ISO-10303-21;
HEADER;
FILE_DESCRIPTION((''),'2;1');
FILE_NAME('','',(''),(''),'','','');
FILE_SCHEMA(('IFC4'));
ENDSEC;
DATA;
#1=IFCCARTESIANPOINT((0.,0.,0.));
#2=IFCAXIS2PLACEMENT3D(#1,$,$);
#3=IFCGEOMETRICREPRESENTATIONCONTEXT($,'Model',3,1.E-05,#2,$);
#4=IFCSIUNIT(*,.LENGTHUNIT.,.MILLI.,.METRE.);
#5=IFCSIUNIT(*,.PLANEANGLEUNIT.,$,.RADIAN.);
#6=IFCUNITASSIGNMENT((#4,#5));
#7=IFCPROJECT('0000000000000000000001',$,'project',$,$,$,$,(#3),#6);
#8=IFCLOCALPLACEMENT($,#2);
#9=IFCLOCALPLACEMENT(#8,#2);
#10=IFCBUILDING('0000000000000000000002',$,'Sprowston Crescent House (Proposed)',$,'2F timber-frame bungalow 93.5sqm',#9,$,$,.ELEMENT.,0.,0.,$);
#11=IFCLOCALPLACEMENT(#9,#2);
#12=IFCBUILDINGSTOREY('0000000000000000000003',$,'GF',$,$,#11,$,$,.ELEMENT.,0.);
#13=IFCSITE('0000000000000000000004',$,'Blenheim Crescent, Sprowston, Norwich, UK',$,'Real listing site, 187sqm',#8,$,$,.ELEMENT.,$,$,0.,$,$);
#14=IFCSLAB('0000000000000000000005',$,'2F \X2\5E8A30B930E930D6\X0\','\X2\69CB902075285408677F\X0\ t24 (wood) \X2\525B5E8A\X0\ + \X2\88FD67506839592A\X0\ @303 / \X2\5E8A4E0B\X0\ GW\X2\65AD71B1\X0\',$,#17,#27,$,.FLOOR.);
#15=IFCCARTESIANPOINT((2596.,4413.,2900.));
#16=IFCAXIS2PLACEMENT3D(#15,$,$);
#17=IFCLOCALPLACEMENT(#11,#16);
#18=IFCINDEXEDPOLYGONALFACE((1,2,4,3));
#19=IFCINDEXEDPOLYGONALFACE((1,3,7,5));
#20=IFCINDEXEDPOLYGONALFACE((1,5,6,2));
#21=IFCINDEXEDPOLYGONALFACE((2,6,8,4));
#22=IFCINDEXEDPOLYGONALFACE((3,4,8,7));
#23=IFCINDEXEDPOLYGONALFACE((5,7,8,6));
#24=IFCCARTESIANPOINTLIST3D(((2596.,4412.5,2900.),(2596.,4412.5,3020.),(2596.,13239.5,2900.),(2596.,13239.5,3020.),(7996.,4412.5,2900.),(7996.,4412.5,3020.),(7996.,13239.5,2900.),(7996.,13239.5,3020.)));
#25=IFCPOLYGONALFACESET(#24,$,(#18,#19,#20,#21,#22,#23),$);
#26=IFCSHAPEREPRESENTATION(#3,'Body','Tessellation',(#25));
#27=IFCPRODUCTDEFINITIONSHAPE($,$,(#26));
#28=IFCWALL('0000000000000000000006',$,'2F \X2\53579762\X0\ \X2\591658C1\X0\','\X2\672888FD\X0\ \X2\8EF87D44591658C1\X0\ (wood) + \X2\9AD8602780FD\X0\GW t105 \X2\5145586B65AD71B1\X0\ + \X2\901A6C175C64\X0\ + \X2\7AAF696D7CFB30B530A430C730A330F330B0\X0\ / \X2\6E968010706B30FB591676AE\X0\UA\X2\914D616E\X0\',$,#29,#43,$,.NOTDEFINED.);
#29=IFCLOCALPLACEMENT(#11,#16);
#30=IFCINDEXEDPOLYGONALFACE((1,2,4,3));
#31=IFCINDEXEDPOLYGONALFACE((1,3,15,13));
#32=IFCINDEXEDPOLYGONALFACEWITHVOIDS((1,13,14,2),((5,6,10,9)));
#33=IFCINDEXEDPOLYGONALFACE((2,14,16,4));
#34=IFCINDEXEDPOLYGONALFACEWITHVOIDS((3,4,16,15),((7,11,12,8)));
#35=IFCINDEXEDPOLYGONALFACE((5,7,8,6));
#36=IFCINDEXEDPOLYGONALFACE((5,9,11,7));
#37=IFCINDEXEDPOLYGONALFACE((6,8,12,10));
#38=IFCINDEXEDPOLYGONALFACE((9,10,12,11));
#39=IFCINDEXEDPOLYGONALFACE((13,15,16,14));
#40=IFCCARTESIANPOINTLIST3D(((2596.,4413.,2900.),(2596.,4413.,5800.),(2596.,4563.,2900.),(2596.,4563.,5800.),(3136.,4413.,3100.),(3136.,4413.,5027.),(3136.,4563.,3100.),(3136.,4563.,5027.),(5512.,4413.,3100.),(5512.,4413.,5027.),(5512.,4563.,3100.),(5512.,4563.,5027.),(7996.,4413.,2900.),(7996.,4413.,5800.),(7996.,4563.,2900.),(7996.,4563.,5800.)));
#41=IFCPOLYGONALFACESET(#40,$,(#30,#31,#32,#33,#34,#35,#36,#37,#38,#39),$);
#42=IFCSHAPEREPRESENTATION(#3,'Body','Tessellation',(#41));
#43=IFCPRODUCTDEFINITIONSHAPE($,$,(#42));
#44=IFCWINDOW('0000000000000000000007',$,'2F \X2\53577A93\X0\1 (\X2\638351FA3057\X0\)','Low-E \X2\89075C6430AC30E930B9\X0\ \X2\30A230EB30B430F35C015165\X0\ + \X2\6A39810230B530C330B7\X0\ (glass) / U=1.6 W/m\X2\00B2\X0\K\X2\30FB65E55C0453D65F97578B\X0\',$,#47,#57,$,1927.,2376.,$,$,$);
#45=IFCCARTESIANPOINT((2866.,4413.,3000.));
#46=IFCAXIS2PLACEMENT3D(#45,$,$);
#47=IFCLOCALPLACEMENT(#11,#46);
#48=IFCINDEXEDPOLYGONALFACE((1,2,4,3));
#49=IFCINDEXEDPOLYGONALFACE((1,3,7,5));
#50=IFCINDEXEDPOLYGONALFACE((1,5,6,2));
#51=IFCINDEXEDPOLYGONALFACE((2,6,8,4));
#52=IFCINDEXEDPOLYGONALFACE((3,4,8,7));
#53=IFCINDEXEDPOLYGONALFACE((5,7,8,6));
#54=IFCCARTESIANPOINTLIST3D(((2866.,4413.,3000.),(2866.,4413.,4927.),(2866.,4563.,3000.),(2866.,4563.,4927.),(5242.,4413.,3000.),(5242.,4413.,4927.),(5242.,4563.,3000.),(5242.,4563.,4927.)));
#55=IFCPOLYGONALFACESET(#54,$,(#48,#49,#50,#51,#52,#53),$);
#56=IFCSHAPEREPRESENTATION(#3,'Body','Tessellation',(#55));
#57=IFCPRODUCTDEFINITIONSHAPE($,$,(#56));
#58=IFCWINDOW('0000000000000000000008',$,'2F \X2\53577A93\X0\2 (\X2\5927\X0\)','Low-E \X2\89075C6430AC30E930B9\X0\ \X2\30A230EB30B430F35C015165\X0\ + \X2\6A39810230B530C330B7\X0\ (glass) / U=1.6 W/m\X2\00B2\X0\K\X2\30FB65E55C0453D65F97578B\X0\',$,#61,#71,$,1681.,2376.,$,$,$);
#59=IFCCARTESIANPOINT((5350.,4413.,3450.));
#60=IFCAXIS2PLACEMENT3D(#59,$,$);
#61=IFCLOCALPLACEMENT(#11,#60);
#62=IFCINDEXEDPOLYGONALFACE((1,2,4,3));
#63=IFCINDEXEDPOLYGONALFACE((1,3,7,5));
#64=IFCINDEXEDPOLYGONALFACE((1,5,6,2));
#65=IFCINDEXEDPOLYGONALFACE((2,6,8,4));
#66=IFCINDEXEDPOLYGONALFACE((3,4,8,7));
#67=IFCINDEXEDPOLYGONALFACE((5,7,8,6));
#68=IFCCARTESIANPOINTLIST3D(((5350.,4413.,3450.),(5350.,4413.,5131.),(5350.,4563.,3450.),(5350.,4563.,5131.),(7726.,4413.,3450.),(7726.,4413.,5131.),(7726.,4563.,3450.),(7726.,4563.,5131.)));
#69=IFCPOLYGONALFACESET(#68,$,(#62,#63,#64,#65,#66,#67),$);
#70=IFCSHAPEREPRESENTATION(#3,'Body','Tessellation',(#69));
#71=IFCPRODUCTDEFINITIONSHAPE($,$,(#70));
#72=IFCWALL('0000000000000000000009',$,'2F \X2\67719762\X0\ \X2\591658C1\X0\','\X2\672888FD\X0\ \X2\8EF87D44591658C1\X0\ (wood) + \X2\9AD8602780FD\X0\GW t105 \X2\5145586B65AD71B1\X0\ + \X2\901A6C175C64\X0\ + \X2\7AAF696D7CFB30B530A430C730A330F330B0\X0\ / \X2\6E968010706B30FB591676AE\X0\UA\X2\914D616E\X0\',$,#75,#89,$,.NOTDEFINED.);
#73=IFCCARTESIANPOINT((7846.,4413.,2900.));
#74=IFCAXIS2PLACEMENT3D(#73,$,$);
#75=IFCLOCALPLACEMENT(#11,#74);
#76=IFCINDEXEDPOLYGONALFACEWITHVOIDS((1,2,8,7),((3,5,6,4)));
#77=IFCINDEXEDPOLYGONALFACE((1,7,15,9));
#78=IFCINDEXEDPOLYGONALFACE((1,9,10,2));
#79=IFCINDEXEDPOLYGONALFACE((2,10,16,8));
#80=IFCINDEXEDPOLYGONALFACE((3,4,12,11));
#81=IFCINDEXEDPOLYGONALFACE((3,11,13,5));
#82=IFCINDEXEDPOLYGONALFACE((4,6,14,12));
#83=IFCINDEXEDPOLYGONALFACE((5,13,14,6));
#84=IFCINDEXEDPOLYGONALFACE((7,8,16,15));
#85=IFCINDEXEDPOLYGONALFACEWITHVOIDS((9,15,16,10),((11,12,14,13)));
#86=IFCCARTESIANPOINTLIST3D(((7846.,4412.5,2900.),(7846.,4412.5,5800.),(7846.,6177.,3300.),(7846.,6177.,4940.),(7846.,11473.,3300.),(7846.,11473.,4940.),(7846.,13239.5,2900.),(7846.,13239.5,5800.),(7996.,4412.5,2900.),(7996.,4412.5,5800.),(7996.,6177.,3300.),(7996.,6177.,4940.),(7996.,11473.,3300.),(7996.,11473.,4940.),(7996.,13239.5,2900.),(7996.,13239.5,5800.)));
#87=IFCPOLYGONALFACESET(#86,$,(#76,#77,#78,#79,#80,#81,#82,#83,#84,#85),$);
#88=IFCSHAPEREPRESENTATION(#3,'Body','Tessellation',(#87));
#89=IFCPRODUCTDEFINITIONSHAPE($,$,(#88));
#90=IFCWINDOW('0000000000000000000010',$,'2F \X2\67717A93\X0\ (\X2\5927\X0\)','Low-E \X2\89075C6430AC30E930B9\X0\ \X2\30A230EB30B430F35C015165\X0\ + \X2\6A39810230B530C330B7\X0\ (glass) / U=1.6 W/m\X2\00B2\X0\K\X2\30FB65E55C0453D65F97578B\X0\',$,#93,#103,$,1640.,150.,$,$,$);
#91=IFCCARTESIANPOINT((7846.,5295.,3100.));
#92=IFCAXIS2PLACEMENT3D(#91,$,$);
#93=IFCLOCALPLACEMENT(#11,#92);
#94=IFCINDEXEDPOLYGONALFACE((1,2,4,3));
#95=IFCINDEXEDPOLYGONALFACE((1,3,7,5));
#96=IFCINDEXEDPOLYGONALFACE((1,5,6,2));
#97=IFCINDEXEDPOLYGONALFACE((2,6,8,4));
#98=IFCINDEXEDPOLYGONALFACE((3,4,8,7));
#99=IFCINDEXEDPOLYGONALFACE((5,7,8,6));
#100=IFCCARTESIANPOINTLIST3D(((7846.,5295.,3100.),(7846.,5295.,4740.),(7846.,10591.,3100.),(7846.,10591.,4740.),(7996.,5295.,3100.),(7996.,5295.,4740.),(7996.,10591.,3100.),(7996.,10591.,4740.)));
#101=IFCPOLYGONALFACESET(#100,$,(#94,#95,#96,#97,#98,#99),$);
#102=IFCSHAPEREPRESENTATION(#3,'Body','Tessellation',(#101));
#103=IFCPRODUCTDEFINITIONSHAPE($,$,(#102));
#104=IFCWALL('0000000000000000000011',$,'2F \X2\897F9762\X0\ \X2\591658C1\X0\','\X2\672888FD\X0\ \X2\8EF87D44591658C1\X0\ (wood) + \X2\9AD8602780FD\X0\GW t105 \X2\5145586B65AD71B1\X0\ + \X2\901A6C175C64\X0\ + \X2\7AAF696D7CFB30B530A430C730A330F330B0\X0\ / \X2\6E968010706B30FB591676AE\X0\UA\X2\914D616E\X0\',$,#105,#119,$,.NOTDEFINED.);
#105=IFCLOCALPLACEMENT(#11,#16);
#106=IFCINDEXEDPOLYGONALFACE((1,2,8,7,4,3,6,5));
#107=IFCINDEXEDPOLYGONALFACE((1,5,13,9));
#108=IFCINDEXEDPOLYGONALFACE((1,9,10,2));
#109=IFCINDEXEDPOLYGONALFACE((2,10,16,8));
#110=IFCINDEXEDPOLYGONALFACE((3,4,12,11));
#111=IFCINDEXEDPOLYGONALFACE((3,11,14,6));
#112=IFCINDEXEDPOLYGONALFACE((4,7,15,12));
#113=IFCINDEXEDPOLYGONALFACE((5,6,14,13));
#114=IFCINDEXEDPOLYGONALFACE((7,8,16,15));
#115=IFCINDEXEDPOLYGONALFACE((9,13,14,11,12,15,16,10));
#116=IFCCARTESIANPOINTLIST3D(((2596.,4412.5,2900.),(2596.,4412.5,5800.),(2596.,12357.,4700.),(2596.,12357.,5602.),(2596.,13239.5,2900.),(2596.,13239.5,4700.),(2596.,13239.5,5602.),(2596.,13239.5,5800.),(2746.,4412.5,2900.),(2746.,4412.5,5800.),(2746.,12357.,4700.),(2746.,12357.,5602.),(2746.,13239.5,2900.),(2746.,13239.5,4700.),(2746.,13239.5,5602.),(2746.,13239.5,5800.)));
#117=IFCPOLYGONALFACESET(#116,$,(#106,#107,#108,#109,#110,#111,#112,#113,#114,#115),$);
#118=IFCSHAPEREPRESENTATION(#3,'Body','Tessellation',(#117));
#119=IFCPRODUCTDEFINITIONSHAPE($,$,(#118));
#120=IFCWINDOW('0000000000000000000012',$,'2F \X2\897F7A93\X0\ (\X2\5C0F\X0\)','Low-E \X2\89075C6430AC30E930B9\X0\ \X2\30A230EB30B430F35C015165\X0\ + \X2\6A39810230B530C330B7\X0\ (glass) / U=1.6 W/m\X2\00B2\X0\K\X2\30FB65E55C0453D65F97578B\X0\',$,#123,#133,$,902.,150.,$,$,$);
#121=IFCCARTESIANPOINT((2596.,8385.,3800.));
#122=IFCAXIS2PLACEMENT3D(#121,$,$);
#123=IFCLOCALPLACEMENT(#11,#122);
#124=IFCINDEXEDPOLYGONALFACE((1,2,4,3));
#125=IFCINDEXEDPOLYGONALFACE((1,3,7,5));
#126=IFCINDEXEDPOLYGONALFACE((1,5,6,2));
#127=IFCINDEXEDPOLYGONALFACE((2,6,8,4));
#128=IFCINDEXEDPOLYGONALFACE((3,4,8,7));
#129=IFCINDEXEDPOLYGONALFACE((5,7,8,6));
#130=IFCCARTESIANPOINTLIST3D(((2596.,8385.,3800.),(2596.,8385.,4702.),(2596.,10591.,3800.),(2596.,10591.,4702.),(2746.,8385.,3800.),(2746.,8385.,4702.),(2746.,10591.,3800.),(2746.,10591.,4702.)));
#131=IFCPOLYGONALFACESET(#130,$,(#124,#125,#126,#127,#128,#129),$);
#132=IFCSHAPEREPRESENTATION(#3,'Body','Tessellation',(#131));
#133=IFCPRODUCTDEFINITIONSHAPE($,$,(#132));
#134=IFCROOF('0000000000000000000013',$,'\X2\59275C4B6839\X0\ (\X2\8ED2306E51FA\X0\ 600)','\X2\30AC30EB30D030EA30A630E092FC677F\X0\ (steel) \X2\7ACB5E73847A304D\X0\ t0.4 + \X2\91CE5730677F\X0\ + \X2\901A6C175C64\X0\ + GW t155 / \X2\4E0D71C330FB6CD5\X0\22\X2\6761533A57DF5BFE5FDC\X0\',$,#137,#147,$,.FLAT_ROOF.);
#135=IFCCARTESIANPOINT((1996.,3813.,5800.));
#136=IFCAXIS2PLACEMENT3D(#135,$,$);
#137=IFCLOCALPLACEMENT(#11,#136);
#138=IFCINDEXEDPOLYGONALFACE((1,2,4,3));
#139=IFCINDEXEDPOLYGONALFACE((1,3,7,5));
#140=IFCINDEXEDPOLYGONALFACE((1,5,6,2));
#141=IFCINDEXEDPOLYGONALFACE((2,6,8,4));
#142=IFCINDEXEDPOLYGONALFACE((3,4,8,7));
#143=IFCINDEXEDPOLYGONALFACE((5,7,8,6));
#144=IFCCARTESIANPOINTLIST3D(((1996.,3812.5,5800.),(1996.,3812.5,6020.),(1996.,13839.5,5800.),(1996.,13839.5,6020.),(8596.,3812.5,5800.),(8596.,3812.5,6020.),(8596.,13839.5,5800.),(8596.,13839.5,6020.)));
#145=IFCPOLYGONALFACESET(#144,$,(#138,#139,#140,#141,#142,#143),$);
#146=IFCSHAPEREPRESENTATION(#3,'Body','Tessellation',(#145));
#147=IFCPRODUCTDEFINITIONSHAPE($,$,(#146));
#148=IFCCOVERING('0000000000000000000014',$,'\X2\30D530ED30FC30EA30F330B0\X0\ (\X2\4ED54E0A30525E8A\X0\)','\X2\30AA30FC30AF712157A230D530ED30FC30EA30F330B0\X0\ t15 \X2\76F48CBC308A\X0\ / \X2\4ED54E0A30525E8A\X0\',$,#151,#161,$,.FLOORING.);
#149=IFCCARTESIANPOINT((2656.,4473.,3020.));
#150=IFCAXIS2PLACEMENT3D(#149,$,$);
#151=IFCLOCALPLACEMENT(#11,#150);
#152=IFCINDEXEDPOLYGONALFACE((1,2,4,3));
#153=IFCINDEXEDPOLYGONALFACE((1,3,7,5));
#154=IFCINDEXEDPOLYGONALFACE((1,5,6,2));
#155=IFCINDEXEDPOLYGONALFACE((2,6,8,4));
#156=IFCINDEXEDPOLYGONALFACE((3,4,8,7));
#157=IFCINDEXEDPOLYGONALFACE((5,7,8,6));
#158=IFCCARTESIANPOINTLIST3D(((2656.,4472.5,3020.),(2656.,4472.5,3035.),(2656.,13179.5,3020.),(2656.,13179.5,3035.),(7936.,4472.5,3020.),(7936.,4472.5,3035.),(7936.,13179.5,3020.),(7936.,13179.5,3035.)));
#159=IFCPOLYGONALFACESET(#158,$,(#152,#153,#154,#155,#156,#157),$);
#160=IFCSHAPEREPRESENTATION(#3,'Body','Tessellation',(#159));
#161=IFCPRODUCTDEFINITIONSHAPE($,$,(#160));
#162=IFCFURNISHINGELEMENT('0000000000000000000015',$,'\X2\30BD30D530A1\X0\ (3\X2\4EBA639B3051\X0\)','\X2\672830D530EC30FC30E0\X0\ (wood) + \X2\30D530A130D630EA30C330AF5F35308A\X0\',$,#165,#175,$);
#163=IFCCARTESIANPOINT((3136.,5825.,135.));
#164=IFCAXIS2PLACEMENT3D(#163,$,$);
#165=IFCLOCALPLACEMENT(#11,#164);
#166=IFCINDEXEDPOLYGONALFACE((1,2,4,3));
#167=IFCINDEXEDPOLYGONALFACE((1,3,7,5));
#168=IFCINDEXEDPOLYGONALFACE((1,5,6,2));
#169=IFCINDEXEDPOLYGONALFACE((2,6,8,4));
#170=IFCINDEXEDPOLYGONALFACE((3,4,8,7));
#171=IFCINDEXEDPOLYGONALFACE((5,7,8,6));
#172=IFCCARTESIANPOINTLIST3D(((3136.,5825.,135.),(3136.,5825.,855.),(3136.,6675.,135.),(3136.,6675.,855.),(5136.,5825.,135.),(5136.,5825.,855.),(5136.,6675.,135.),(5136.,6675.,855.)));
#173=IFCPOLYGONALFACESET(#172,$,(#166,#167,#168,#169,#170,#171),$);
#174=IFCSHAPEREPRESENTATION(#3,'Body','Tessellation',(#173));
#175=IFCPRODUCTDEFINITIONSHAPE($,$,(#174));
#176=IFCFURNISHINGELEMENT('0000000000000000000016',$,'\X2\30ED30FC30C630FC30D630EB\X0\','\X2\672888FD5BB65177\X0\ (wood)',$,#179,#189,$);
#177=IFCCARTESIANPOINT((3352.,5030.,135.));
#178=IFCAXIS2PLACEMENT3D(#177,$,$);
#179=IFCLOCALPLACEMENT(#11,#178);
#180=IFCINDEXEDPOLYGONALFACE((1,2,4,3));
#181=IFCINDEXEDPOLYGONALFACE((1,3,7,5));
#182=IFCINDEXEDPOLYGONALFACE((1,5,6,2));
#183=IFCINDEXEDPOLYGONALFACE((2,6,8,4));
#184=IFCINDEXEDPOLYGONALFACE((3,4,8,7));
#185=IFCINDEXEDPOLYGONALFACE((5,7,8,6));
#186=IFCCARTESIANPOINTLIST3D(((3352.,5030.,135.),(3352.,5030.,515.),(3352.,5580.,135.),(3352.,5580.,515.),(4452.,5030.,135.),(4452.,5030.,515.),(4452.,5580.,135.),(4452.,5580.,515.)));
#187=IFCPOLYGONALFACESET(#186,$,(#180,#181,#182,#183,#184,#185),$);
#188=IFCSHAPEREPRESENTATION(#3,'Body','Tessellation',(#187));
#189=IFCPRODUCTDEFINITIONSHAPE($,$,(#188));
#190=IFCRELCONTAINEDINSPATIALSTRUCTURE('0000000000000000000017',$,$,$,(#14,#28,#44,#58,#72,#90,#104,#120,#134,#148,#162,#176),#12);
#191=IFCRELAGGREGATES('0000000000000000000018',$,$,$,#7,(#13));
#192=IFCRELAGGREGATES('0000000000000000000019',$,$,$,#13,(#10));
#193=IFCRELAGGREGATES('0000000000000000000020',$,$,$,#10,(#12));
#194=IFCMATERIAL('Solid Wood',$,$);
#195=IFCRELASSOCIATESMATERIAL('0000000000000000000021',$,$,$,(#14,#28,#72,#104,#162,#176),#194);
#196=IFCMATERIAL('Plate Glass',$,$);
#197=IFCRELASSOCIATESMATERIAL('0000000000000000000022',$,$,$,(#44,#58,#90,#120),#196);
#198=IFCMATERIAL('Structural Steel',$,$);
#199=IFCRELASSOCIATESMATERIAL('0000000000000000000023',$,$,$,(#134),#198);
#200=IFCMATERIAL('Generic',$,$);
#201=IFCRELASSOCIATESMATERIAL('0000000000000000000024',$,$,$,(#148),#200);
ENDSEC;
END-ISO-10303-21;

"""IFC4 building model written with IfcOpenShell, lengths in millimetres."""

from ifc_helpers import new_model, si_unit, frame, frame_2d, origin, place, context, project, spatial, rectangle, extrude, material, element, fill, save


model = new_model("IFC4")

# Units and contexts
model_context = context("Model", 3, precision=1e-05, world=origin())
ifc_project = project(units=[si_unit("LENGTHUNIT", "METRE", prefix="MILLI"), si_unit("PLANEANGLEUNIT", "RADIAN")], contexts=[model_context])

# Site, building, storey
site_placement = place(None, origin())
site = spatial("IfcSite", under=ifc_project, at=site_placement, Name="Blenheim Crescent, Sprowston, Norwich, UK", ObjectType="Real listing site, 187sqm", CompositionType="ELEMENT", RefElevation=0.0)
building_placement = place(site_placement, origin())
building = spatial("IfcBuilding", under=site, at=building_placement, Name="Sprowston Crescent House (Proposed)", ObjectType="2F timber-frame bungalow 93.5sqm", CompositionType="ELEMENT", ElevationOfRefHeight=0.0, ElevationOfTerrain=0.0)
storey_placement = place(building_placement, origin())
storey = spatial("IfcBuildingStorey", under=building, at=storey_placement, Name="GF", CompositionType="ELEMENT", Elevation=0.0)

# Slab
ifc_material_1 = material(Name="Solid Wood")
slab_placement = place(storey_placement, frame((2596.0, 4413.0, 2900.0)))
element("IfcSlab", 1, at=slab_placement, inside=storey, material=ifc_material_1, Name="2F 床スラブ", Description="構造用合板 t24 (wood) 剛床 + 製材根太 @303 / 床下 GW断熱", PredefinedType="FLOOR", context=model_context, shape_type="SweptSolid", body=[
    extrude(rectangle(XDim=5400.0, YDim=8827.0, at=frame_2d((2700.0, 4413.0))), frame((2596.0, 4413.0, 2900.0)), (0.0, 0.0, 1.0), 120.0),
])

# Wall, openings, windows
wall_1_placement = place(storey_placement, frame((2596.0, 4413.0, 2900.0)))
wall_1 = element("IfcWall", 2, at=wall_1_placement, inside=storey, material=ifc_material_1, Name="2F 南面 外壁", Description="木製 軸組外壁 (wood) + 高性能GW t105 充填断熱 + 通気層 + 窯業系サイディング / 準耐火・外皮UA配慮", PredefinedType="NOTDEFINED", context=model_context, shape_type="SweptSolid", body=[
    extrude(rectangle(XDim=5400.0, YDim=150.0, at=frame_2d((2700.0, 75.0))), frame((2596.0, 4413.0, 2900.0)), (0.0, 0.0, 1.0), 2900.0),
])
opening_1_placement = place(storey_placement, frame((2866.0, 4413.0, 3000.0)))
opening_1 = element("IfcOpeningElement", 3, at=opening_1_placement, cuts=wall_1, PredefinedType="NOTDEFINED", context=model_context, shape_type="SweptSolid", body=[
    extrude(rectangle(XDim=2376.0, YDim=150.0, at=frame_2d((1188.0, 75.0))), frame((2866.0, 4413.0, 3000.0)), (0.0, 0.0, 1.0), 1927.0),
])
opening_2_placement = place(storey_placement, frame((5350.0, 4413.0, 3450.0)))
opening_2 = element("IfcOpeningElement", 4, at=opening_2_placement, cuts=wall_1, PredefinedType="NOTDEFINED", context=model_context, shape_type="SweptSolid", body=[
    extrude(rectangle(XDim=2376.0, YDim=150.0, at=frame_2d((1188.0, 75.0))), frame((5350.0, 4413.0, 3450.0)), (0.0, 0.0, 1.0), 1681.0),
])
ifc_material_2 = material(Name="Plate Glass")
window_1_placement = place(storey_placement, frame((2866.0, 4413.0, 3000.0)))
window_1 = element("IfcWindow", 5, at=window_1_placement, inside=storey, material=ifc_material_2, Name="2F 南窓1 (掃出し)", Description="Low-E 複層ガラス アルゴン封入 + 樹脂サッシ (glass) / U=1.6 W/m²K・日射取得型", OverallHeight=1927.0, OverallWidth=2376.0, context=model_context, shape_type="SweptSolid", body=[
    extrude(rectangle(XDim=2376.0, YDim=150.0, at=frame_2d((1188.0, 75.0))), frame((2866.0, 4413.0, 3000.0)), (0.0, 0.0, 1.0), 1927.0),
])
fill(opening_1, window_1)
window_2_placement = place(storey_placement, frame((5350.0, 4413.0, 3450.0)))
window_2 = element("IfcWindow", 6, at=window_2_placement, inside=storey, material=ifc_material_2, Name="2F 南窓2 (大)", Description="Low-E 複層ガラス アルゴン封入 + 樹脂サッシ (glass) / U=1.6 W/m²K・日射取得型", OverallHeight=1681.0, OverallWidth=2376.0, context=model_context, shape_type="SweptSolid", body=[
    extrude(rectangle(XDim=2376.0, YDim=150.0, at=frame_2d((1188.0, 75.0))), frame((5350.0, 4413.0, 3450.0)), (0.0, 0.0, 1.0), 1681.0),
])
fill(opening_2, window_2)

# Walls, openings, windows
wall_2_placement = place(storey_placement, frame((7846.0, 4413.0, 2900.0)))
wall_2 = element("IfcWall", 7, at=wall_2_placement, inside=storey, material=ifc_material_1, Name="2F 東面 外壁", Description="木製 軸組外壁 (wood) + 高性能GW t105 充填断熱 + 通気層 + 窯業系サイディング / 準耐火・外皮UA配慮", PredefinedType="NOTDEFINED", context=model_context, shape_type="SweptSolid", body=[
    extrude(rectangle(XDim=150.0, YDim=8827.0, at=frame_2d((75.0, 4413.0))), frame((7846.0, 4413.0, 2900.0)), (0.0, 0.0, 1.0), 2900.0),
])
opening_3_placement = place(storey_placement, frame((7846.0, 5295.0, 3100.0)))
opening_3 = element("IfcOpeningElement", 8, at=opening_3_placement, cuts=wall_2, PredefinedType="NOTDEFINED", context=model_context, shape_type="SweptSolid", body=[
    extrude(rectangle(XDim=150.0, YDim=5296.0, at=frame_2d((75.0, 2648.0))), frame((7846.0, 5295.0, 3100.0)), (0.0, 0.0, 1.0), 1640.0),
])
window_3_placement = place(storey_placement, frame((7846.0, 5295.0, 3100.0)))
window_3 = element("IfcWindow", 9, at=window_3_placement, inside=storey, material=ifc_material_2, Name="2F 東窓 (大)", Description="Low-E 複層ガラス アルゴン封入 + 樹脂サッシ (glass) / U=1.6 W/m²K・日射取得型", OverallHeight=1640.0, OverallWidth=150.0, context=model_context, shape_type="SweptSolid", body=[
    extrude(rectangle(XDim=150.0, YDim=5296.0, at=frame_2d((75.0, 2648.0))), frame((7846.0, 5295.0, 3100.0)), (0.0, 0.0, 1.0), 1640.0),
])
fill(opening_3, window_3)
wall_3_placement = place(storey_placement, frame((2596.0, 4413.0, 2900.0)))
wall_3 = element("IfcWall", 10, at=wall_3_placement, inside=storey, material=ifc_material_1, Name="2F 西面 外壁", Description="木製 軸組外壁 (wood) + 高性能GW t105 充填断熱 + 通気層 + 窯業系サイディング / 準耐火・外皮UA配慮", PredefinedType="NOTDEFINED", context=model_context, shape_type="SweptSolid", body=[
    extrude(rectangle(XDim=150.0, YDim=8827.0, at=frame_2d((75.0, 4413.0))), frame((2596.0, 4413.0, 2900.0)), (0.0, 0.0, 1.0), 2900.0),
])
opening_4_placement = place(storey_placement, frame((2596.0, 8385.0, 3800.0)))
opening_4 = element("IfcOpeningElement", 11, at=opening_4_placement, cuts=wall_3, PredefinedType="NOTDEFINED", context=model_context, shape_type="SweptSolid", body=[
    extrude(rectangle(XDim=150.0, YDim=2206.0, at=frame_2d((75.0, 1103.0))), frame((2596.0, 8385.0, 3800.0)), (0.0, 0.0, 1.0), 902.0),
])
window_4_placement = place(storey_placement, frame((2596.0, 8385.0, 3800.0)))
window_4 = element("IfcWindow", 12, at=window_4_placement, inside=storey, material=ifc_material_2, Name="2F 西窓 (小)", Description="Low-E 複層ガラス アルゴン封入 + 樹脂サッシ (glass) / U=1.6 W/m²K・日射取得型", OverallHeight=902.0, OverallWidth=150.0, context=model_context, shape_type="SweptSolid", body=[
    extrude(rectangle(XDim=150.0, YDim=2206.0, at=frame_2d((75.0, 1103.0))), frame((2596.0, 8385.0, 3800.0)), (0.0, 0.0, 1.0), 902.0),
])
fill(opening_4, window_4)

# Roof
ifc_material_3 = material(Name="Structural Steel")
roof_placement = place(storey_placement, frame((1996.0, 3813.0, 5800.0)))
element("IfcRoof", 13, at=roof_placement, inside=storey, material=ifc_material_3, Name="大屋根 (軒の出 600)", Description="ガルバリウム鋼板 (steel) 立平葺き t0.4 + 野地板 + 通気層 + GW t155 / 不燃・法22条区域対応", PredefinedType="FLAT_ROOF", context=model_context, shape_type="SweptSolid", body=[
    extrude(rectangle(XDim=6600.0, YDim=10027.0, at=frame_2d((3300.0, 5013.0))), frame((1996.0, 3813.0, 5800.0)), (0.0, 0.0, 1.0), 220.0),
])

# Covering
ifc_material_4 = material(Name="Generic")
covering_placement = place(storey_placement, frame((2656.0, 4473.0, 3020.0)))
element("IfcCovering", 14, at=covering_placement, inside=storey, material=ifc_material_4, Name="フローリング (仕上げ床)", Description="オーク無垢フローリング t15 直貼り / 仕上げ床", PredefinedType="FLOORING", context=model_context, shape_type="SweptSolid", body=[
    extrude(rectangle(XDim=5280.0, YDim=8707.0, at=frame_2d((2640.0, 4353.0))), frame((2656.0, 4473.0, 3020.0)), (0.0, 0.0, 1.0), 15.0),
])

# Furnishing elements
furnishing_1_placement = place(storey_placement, frame((3136.0, 5825.0, 135.0)))
element("IfcFurnishingElement", 15, at=furnishing_1_placement, inside=storey, material=ifc_material_1, Name="ソファ (3人掛け)", Description="木フレーム (wood) + ファブリック張り", context=model_context, shape_type="SweptSolid", body=[
    extrude(rectangle(XDim=2000.0, YDim=850.0, at=frame_2d((1000.0, 425.0))), frame((3136.0, 5825.0, 135.0)), (0.0, 0.0, 1.0), 720.0),
])
furnishing_2_placement = place(storey_placement, frame((3352.0, 5030.0, 135.0)))
element("IfcFurnishingElement", 16, at=furnishing_2_placement, inside=storey, material=ifc_material_1, Name="ローテーブル", Description="木製家具 (wood)", context=model_context, shape_type="SweptSolid", body=[
    extrude(rectangle(XDim=1100.0, YDim=550.0, at=frame_2d((550.0, 275.0))), frame((3352.0, 5030.0, 135.0)), (0.0, 0.0, 1.0), 380.0),
])

save(model, "model.ifc")
